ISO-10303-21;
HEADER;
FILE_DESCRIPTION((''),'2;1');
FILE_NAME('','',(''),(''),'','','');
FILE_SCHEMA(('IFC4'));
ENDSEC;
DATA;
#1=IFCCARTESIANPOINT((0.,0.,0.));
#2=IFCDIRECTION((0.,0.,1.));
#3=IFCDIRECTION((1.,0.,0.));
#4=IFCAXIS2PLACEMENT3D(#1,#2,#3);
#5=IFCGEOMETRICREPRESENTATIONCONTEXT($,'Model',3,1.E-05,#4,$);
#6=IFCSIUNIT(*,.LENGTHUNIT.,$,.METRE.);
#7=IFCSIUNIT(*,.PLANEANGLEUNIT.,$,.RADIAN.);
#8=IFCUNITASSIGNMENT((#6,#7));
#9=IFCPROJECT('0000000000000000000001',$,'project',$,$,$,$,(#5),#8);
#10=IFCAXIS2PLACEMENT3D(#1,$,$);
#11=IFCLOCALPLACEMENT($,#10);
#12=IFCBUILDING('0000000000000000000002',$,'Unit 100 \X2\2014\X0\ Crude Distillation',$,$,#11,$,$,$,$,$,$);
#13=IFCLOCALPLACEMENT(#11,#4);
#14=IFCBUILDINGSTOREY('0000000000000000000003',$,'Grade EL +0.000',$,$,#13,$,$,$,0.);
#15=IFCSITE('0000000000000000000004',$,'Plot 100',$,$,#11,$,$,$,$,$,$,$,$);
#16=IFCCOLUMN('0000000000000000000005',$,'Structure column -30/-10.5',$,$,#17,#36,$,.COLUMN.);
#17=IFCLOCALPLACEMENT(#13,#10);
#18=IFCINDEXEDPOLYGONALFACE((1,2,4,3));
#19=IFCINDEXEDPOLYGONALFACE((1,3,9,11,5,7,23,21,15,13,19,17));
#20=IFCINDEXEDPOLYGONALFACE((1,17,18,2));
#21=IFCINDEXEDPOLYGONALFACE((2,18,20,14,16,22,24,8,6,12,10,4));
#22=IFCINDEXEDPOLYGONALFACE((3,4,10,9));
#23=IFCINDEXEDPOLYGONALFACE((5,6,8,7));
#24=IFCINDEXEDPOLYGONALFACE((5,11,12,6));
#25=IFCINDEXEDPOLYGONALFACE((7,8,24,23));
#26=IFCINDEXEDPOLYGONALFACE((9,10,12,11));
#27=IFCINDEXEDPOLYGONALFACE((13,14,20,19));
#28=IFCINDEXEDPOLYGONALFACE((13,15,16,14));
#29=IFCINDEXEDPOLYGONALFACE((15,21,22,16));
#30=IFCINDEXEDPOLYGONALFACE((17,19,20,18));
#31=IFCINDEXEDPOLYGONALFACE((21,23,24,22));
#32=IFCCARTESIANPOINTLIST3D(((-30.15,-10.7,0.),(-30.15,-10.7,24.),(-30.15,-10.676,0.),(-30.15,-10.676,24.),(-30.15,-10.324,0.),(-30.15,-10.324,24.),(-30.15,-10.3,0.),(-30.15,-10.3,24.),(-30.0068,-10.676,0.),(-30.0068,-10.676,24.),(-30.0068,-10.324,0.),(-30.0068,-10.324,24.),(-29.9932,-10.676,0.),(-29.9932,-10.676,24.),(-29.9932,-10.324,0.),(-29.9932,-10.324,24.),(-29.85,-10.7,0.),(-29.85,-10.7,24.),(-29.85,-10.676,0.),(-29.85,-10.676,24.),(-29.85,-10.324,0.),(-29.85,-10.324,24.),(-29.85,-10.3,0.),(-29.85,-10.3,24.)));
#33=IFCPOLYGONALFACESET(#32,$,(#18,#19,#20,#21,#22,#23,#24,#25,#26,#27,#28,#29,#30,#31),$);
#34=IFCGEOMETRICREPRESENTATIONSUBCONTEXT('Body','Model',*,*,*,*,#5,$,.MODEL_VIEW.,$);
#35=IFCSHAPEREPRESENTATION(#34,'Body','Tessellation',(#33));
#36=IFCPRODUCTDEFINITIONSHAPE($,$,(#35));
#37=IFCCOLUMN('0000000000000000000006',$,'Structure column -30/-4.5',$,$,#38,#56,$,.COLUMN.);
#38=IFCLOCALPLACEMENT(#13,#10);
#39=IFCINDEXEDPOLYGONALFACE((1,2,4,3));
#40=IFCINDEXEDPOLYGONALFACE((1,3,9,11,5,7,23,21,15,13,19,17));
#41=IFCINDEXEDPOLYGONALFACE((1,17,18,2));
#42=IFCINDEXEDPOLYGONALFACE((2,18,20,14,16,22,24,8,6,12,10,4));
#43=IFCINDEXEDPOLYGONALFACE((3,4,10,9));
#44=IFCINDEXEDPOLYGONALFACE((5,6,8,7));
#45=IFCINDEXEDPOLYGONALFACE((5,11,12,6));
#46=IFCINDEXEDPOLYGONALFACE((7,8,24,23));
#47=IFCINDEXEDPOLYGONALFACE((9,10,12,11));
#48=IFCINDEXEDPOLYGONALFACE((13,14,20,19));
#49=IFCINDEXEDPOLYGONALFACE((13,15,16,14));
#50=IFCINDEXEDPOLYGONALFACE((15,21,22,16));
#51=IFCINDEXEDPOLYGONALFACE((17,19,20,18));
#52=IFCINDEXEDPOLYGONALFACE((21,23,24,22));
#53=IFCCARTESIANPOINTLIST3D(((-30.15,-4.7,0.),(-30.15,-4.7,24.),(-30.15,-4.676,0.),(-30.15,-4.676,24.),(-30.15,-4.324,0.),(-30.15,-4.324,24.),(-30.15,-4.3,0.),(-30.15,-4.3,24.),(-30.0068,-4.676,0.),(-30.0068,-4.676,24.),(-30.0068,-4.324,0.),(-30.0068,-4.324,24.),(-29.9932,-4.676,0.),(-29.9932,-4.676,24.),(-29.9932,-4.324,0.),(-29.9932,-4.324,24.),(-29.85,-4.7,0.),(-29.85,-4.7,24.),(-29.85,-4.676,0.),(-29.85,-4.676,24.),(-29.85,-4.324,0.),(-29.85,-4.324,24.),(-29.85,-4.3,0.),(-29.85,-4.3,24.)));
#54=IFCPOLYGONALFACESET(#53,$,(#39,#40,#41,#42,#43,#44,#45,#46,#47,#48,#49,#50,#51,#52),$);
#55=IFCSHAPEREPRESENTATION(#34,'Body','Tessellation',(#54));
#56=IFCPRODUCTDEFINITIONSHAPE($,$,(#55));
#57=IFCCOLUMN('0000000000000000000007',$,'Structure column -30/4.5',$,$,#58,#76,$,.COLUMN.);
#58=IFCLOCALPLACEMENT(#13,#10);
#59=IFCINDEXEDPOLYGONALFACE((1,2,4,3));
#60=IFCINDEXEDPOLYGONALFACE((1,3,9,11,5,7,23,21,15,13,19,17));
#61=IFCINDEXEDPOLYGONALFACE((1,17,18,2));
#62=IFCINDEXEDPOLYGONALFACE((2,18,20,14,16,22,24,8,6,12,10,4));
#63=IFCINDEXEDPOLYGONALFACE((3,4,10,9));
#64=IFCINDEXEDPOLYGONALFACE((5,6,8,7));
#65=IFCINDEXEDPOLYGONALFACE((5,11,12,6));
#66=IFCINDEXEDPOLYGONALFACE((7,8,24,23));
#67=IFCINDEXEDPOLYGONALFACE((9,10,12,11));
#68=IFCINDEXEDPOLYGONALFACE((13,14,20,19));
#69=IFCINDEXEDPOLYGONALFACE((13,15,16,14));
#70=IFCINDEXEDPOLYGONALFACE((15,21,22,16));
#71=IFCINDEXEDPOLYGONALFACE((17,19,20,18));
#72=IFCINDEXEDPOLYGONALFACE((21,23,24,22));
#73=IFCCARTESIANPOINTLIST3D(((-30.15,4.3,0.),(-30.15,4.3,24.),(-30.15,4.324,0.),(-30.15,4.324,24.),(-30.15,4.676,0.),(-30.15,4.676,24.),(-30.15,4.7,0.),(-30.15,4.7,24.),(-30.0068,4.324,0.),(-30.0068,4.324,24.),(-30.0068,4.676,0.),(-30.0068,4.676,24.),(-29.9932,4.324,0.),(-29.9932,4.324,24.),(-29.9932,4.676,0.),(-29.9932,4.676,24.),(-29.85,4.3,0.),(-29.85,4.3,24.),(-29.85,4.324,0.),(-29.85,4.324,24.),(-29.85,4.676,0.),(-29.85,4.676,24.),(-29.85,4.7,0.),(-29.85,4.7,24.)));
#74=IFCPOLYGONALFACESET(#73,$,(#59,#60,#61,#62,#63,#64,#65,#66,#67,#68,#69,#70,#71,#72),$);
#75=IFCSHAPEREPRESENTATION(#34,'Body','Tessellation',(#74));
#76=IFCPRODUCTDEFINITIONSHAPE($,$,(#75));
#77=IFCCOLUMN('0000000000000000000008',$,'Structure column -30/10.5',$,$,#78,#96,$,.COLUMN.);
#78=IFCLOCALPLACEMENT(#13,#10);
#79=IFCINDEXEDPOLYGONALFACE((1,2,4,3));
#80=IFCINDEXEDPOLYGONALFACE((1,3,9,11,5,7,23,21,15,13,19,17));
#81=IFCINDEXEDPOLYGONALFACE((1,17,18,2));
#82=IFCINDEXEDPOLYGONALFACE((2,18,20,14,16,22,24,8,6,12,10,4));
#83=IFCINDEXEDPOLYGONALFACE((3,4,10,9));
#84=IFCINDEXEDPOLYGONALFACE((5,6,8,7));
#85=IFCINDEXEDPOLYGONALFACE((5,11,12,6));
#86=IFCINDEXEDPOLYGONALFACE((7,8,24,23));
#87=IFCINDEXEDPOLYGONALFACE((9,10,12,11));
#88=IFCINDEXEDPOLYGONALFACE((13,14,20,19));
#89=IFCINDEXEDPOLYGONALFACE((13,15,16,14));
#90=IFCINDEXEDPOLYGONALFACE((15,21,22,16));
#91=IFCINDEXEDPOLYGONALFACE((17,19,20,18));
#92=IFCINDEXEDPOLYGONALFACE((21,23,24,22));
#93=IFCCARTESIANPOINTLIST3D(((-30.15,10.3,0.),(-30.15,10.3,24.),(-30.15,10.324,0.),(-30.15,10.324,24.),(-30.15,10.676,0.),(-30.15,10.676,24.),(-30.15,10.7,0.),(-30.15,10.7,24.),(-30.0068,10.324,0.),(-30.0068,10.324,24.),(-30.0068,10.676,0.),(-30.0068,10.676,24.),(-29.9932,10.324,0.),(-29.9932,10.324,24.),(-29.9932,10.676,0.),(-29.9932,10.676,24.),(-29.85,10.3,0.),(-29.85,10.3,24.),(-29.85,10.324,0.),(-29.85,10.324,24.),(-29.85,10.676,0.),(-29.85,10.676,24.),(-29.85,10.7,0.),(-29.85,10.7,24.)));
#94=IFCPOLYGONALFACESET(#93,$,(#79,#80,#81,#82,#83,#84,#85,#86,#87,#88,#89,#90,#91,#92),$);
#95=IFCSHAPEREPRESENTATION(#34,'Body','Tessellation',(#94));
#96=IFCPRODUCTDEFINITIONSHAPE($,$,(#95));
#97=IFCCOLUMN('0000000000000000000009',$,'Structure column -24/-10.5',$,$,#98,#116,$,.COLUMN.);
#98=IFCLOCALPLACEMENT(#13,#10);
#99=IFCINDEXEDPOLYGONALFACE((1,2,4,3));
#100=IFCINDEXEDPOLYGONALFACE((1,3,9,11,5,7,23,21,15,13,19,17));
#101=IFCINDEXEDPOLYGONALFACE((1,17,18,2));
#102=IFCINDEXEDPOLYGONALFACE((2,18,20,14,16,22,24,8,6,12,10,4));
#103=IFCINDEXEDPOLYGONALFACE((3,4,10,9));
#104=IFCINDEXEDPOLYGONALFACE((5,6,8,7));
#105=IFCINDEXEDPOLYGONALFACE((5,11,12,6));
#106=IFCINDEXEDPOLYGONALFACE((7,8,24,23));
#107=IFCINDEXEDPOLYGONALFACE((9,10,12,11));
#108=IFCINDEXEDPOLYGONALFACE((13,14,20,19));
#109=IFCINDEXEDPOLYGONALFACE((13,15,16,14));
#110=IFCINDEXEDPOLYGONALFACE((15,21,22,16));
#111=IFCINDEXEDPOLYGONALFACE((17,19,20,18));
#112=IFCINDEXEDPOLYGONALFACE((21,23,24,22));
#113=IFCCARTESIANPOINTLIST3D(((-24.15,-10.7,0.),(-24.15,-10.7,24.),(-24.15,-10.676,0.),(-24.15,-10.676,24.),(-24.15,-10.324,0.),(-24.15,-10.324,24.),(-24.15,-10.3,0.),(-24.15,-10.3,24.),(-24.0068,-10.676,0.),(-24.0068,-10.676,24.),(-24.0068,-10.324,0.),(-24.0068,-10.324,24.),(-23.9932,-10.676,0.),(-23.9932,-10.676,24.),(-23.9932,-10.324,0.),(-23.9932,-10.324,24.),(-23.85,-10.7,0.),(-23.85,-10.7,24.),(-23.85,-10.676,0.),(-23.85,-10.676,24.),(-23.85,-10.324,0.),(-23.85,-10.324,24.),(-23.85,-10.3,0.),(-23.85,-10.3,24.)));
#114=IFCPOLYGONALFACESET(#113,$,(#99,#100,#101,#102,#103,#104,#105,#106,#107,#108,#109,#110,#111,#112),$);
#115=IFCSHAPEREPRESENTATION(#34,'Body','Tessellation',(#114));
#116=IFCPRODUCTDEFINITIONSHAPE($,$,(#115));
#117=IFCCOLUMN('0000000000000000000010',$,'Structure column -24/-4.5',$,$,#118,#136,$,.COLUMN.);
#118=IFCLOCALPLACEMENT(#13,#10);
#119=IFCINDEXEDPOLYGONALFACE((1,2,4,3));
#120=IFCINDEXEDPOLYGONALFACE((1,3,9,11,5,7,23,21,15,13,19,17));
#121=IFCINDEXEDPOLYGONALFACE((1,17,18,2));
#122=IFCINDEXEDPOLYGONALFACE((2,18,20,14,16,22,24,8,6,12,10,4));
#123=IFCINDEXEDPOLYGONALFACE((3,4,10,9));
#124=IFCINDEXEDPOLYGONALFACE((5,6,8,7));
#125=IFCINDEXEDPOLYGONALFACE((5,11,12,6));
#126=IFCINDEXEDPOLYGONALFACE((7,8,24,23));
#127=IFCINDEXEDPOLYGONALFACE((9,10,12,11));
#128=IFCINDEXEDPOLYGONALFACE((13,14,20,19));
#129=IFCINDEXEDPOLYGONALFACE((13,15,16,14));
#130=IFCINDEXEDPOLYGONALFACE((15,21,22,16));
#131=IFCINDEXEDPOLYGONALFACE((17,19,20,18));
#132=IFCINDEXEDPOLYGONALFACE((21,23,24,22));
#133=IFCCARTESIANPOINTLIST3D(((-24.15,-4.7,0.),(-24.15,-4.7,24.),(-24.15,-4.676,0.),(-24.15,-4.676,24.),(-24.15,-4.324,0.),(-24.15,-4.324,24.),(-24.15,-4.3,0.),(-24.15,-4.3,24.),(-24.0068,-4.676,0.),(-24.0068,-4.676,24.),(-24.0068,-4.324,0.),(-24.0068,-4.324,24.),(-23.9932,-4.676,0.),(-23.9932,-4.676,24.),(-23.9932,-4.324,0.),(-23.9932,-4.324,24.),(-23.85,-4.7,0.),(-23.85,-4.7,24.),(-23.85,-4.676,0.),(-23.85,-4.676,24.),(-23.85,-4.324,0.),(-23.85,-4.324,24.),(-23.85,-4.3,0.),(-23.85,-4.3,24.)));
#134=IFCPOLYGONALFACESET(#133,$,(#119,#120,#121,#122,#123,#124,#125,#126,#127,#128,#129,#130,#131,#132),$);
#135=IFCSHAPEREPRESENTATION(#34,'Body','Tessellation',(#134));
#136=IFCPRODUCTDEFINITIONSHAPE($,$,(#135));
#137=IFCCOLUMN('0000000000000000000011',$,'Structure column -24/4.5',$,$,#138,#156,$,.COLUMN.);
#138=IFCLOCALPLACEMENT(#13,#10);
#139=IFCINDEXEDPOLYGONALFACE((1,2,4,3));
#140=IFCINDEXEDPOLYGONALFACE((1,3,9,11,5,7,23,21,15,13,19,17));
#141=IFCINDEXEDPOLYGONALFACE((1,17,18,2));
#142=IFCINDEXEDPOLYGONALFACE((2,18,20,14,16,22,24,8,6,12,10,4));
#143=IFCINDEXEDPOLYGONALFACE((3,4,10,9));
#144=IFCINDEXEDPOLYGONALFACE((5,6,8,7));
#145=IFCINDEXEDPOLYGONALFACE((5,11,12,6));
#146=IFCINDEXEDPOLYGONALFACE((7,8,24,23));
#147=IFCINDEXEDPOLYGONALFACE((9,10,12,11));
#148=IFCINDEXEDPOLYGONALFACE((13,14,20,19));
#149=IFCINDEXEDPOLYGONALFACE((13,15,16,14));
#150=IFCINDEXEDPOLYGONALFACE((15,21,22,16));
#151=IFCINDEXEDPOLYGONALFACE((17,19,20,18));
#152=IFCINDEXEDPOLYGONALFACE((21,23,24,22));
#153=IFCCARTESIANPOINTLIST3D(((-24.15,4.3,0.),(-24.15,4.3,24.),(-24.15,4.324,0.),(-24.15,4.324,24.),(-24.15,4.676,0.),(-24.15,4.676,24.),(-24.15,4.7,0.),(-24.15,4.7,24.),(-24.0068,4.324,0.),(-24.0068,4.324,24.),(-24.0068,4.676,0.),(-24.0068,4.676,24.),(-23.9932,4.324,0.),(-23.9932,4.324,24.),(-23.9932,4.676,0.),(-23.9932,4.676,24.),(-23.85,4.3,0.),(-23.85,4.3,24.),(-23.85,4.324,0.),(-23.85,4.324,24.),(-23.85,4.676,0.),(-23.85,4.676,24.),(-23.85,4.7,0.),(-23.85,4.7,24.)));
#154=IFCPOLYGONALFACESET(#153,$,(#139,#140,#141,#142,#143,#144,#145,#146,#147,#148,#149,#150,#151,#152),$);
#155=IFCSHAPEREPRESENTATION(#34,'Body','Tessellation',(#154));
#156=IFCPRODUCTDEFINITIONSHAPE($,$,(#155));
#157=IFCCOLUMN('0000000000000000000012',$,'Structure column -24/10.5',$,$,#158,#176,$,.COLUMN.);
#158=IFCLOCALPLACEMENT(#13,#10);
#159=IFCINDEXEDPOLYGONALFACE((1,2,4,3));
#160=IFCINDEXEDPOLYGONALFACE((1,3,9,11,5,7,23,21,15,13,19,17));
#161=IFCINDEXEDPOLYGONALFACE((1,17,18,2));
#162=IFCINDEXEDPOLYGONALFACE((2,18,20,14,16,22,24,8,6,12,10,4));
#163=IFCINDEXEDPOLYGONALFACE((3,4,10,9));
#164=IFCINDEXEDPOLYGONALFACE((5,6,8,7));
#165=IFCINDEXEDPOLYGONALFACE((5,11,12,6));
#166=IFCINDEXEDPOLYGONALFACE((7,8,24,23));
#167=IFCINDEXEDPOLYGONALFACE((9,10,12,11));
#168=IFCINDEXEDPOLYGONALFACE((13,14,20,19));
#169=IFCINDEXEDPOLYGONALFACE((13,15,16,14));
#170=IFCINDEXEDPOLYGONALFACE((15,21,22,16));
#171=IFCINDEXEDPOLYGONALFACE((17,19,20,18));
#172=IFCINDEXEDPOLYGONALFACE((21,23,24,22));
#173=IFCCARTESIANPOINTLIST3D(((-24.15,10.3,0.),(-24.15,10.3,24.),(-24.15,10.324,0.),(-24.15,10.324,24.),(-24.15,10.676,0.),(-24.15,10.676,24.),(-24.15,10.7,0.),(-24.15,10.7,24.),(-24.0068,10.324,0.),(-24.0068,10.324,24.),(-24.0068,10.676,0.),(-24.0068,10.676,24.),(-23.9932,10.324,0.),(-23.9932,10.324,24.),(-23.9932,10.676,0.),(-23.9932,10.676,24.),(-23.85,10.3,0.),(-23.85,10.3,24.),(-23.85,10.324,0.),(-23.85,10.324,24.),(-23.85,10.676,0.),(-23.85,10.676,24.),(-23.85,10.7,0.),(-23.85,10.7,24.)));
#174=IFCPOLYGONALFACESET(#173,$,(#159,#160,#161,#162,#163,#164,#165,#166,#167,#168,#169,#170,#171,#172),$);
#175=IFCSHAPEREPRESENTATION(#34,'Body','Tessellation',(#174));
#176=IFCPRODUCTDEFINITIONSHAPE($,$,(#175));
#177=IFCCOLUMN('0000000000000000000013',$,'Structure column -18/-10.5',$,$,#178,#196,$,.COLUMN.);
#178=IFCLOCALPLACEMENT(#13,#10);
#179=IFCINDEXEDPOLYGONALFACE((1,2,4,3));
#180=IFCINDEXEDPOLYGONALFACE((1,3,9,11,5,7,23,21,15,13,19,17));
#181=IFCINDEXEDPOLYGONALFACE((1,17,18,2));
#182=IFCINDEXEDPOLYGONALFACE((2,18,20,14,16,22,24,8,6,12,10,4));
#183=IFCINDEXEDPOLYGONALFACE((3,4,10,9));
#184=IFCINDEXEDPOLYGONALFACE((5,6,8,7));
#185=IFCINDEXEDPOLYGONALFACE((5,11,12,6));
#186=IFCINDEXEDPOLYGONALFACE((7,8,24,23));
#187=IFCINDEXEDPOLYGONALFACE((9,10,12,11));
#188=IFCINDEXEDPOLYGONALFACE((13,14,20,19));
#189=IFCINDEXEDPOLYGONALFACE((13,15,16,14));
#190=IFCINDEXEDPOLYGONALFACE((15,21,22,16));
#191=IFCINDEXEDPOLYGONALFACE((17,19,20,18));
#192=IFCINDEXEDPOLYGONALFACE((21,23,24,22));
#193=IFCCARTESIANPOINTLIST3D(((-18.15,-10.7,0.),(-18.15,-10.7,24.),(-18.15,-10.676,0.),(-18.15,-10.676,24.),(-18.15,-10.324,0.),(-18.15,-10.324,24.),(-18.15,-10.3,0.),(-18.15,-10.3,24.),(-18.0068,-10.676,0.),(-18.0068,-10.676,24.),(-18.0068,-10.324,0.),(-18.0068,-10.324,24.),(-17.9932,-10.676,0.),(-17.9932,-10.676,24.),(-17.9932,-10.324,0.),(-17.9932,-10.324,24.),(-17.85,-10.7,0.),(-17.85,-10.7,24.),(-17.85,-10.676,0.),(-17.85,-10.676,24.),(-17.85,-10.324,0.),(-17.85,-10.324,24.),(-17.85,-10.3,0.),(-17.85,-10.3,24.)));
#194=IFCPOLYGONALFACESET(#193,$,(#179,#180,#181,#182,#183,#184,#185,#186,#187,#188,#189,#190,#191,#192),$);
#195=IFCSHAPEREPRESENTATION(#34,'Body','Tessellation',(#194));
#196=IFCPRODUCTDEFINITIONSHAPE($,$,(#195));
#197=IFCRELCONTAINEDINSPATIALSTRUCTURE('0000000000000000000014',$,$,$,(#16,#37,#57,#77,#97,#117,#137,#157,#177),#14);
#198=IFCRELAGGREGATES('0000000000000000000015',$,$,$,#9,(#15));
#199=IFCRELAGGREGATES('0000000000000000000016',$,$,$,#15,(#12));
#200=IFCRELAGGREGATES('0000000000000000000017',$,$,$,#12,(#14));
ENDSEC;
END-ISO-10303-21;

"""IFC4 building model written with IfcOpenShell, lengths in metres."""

from ifc_helpers import new_model, si_unit, frame, origin, origin_with_axes, origin_2d, place, context, subcontext, project, spatial, i_section, extrude, element, save


model = new_model("IFC4")

# Units and contexts
model_context = context("Model", 3, precision=1e-05, world=origin_with_axes())
body_context = subcontext(model_context, "Body", "Model", "MODEL_VIEW")
ifc_project = project(units=[si_unit("LENGTHUNIT", "METRE"), si_unit("PLANEANGLEUNIT", "RADIAN")], contexts=[model_context])

# Site, building, storey
placement = place(None, origin())
site = spatial("IfcSite", under=ifc_project, at=placement, Name="Plot 100")
building = spatial("IfcBuilding", under=site, at=placement, Name="Unit 100 — Crude Distillation")
storey_placement = place(placement, origin_with_axes())
storey = spatial("IfcBuildingStorey", under=building, at=storey_placement, Name="Grade EL +0.000", Elevation=0.0)

# Columns
column_1_placement = place(storey_placement, origin_with_axes())
element("IfcColumn", 1, at=column_1_placement, inside=storey, Name="Structure column -30/-10.5", PredefinedType="COLUMN", context=body_context, shape_type="SweptSolid", body=[
    extrude(i_section(OverallWidth=0.3, OverallDepth=0.4, WebThickness=0.0135, FlangeThickness=0.024, at=origin_2d()), frame((-30.0, -10.5, 0.0), z_axis=(0.0, 0.0, 1.0), x_axis=(1.0, 0.0, 0.0)), (0.0, 0.0, 1.0), 24.0),
])
column_2_placement = place(storey_placement, origin_with_axes())
element("IfcColumn", 2, at=column_2_placement, inside=storey, Name="Structure column -30/-4.5", PredefinedType="COLUMN", context=body_context, shape_type="SweptSolid", body=[
    extrude(i_section(OverallWidth=0.3, OverallDepth=0.4, WebThickness=0.0135, FlangeThickness=0.024, at=origin_2d()), frame((-30.0, -4.5, 0.0), z_axis=(0.0, 0.0, 1.0), x_axis=(1.0, 0.0, 0.0)), (0.0, 0.0, 1.0), 24.0),
])
column_3_placement = place(storey_placement, origin_with_axes())
element("IfcColumn", 3, at=column_3_placement, inside=storey, Name="Structure column -30/4.5", PredefinedType="COLUMN", context=body_context, shape_type="SweptSolid", body=[
    extrude(i_section(OverallWidth=0.3, OverallDepth=0.4, WebThickness=0.0135, FlangeThickness=0.024, at=origin_2d()), frame((-30.0, 4.5, 0.0), z_axis=(0.0, 0.0, 1.0), x_axis=(1.0, 0.0, 0.0)), (0.0, 0.0, 1.0), 24.0),
])
column_4_placement = place(storey_placement, origin_with_axes())
element("IfcColumn", 4, at=column_4_placement, inside=storey, Name="Structure column -30/10.5", PredefinedType="COLUMN", context=body_context, shape_type="SweptSolid", body=[
    extrude(i_section(OverallWidth=0.3, OverallDepth=0.4, WebThickness=0.0135, FlangeThickness=0.024, at=origin_2d()), frame((-30.0, 10.5, 0.0), z_axis=(0.0, 0.0, 1.0), x_axis=(1.0, 0.0, 0.0)), (0.0, 0.0, 1.0), 24.0),
])
column_5_placement = place(storey_placement, origin_with_axes())
element("IfcColumn", 5, at=column_5_placement, inside=storey, Name="Structure column -24/-10.5", PredefinedType="COLUMN", context=body_context, shape_type="SweptSolid", body=[
    extrude(i_section(OverallWidth=0.3, OverallDepth=0.4, WebThickness=0.0135, FlangeThickness=0.024, at=origin_2d()), frame((-24.0, -10.5, 0.0), z_axis=(0.0, 0.0, 1.0), x_axis=(1.0, 0.0, 0.0)), (0.0, 0.0, 1.0), 24.0),
])
column_6_placement = place(storey_placement, origin_with_axes())
element("IfcColumn", 6, at=column_6_placement, inside=storey, Name="Structure column -24/-4.5", PredefinedType="COLUMN", context=body_context, shape_type="SweptSolid", body=[
    extrude(i_section(OverallWidth=0.3, OverallDepth=0.4, WebThickness=0.0135, FlangeThickness=0.024, at=origin_2d()), frame((-24.0, -4.5, 0.0), z_axis=(0.0, 0.0, 1.0), x_axis=(1.0, 0.0, 0.0)), (0.0, 0.0, 1.0), 24.0),
])
column_7_placement = place(storey_placement, origin_with_axes())
element("IfcColumn", 7, at=column_7_placement, inside=storey, Name="Structure column -24/4.5", PredefinedType="COLUMN", context=body_context, shape_type="SweptSolid", body=[
    extrude(i_section(OverallWidth=0.3, OverallDepth=0.4, WebThickness=0.0135, FlangeThickness=0.024, at=origin_2d()), frame((-24.0, 4.5, 0.0), z_axis=(0.0, 0.0, 1.0), x_axis=(1.0, 0.0, 0.0)), (0.0, 0.0, 1.0), 24.0),
])
column_8_placement = place(storey_placement, origin_with_axes())
element("IfcColumn", 8, at=column_8_placement, inside=storey, Name="Structure column -24/10.5", PredefinedType="COLUMN", context=body_context, shape_type="SweptSolid", body=[
    extrude(i_section(OverallWidth=0.3, OverallDepth=0.4, WebThickness=0.0135, FlangeThickness=0.024, at=origin_2d()), frame((-24.0, 10.5, 0.0), z_axis=(0.0, 0.0, 1.0), x_axis=(1.0, 0.0, 0.0)), (0.0, 0.0, 1.0), 24.0),
])
column_9_placement = place(storey_placement, origin_with_axes())
element("IfcColumn", 9, at=column_9_placement, inside=storey, Name="Structure column -18/-10.5", PredefinedType="COLUMN", context=body_context, shape_type="SweptSolid", body=[
    extrude(i_section(OverallWidth=0.3, OverallDepth=0.4, WebThickness=0.0135, FlangeThickness=0.024, at=origin_2d()), frame((-18.0, -10.5, 0.0), z_axis=(0.0, 0.0, 1.0), x_axis=(1.0, 0.0, 0.0)), (0.0, 0.0, 1.0), 24.0),
])

save(model, "model.ifc")
